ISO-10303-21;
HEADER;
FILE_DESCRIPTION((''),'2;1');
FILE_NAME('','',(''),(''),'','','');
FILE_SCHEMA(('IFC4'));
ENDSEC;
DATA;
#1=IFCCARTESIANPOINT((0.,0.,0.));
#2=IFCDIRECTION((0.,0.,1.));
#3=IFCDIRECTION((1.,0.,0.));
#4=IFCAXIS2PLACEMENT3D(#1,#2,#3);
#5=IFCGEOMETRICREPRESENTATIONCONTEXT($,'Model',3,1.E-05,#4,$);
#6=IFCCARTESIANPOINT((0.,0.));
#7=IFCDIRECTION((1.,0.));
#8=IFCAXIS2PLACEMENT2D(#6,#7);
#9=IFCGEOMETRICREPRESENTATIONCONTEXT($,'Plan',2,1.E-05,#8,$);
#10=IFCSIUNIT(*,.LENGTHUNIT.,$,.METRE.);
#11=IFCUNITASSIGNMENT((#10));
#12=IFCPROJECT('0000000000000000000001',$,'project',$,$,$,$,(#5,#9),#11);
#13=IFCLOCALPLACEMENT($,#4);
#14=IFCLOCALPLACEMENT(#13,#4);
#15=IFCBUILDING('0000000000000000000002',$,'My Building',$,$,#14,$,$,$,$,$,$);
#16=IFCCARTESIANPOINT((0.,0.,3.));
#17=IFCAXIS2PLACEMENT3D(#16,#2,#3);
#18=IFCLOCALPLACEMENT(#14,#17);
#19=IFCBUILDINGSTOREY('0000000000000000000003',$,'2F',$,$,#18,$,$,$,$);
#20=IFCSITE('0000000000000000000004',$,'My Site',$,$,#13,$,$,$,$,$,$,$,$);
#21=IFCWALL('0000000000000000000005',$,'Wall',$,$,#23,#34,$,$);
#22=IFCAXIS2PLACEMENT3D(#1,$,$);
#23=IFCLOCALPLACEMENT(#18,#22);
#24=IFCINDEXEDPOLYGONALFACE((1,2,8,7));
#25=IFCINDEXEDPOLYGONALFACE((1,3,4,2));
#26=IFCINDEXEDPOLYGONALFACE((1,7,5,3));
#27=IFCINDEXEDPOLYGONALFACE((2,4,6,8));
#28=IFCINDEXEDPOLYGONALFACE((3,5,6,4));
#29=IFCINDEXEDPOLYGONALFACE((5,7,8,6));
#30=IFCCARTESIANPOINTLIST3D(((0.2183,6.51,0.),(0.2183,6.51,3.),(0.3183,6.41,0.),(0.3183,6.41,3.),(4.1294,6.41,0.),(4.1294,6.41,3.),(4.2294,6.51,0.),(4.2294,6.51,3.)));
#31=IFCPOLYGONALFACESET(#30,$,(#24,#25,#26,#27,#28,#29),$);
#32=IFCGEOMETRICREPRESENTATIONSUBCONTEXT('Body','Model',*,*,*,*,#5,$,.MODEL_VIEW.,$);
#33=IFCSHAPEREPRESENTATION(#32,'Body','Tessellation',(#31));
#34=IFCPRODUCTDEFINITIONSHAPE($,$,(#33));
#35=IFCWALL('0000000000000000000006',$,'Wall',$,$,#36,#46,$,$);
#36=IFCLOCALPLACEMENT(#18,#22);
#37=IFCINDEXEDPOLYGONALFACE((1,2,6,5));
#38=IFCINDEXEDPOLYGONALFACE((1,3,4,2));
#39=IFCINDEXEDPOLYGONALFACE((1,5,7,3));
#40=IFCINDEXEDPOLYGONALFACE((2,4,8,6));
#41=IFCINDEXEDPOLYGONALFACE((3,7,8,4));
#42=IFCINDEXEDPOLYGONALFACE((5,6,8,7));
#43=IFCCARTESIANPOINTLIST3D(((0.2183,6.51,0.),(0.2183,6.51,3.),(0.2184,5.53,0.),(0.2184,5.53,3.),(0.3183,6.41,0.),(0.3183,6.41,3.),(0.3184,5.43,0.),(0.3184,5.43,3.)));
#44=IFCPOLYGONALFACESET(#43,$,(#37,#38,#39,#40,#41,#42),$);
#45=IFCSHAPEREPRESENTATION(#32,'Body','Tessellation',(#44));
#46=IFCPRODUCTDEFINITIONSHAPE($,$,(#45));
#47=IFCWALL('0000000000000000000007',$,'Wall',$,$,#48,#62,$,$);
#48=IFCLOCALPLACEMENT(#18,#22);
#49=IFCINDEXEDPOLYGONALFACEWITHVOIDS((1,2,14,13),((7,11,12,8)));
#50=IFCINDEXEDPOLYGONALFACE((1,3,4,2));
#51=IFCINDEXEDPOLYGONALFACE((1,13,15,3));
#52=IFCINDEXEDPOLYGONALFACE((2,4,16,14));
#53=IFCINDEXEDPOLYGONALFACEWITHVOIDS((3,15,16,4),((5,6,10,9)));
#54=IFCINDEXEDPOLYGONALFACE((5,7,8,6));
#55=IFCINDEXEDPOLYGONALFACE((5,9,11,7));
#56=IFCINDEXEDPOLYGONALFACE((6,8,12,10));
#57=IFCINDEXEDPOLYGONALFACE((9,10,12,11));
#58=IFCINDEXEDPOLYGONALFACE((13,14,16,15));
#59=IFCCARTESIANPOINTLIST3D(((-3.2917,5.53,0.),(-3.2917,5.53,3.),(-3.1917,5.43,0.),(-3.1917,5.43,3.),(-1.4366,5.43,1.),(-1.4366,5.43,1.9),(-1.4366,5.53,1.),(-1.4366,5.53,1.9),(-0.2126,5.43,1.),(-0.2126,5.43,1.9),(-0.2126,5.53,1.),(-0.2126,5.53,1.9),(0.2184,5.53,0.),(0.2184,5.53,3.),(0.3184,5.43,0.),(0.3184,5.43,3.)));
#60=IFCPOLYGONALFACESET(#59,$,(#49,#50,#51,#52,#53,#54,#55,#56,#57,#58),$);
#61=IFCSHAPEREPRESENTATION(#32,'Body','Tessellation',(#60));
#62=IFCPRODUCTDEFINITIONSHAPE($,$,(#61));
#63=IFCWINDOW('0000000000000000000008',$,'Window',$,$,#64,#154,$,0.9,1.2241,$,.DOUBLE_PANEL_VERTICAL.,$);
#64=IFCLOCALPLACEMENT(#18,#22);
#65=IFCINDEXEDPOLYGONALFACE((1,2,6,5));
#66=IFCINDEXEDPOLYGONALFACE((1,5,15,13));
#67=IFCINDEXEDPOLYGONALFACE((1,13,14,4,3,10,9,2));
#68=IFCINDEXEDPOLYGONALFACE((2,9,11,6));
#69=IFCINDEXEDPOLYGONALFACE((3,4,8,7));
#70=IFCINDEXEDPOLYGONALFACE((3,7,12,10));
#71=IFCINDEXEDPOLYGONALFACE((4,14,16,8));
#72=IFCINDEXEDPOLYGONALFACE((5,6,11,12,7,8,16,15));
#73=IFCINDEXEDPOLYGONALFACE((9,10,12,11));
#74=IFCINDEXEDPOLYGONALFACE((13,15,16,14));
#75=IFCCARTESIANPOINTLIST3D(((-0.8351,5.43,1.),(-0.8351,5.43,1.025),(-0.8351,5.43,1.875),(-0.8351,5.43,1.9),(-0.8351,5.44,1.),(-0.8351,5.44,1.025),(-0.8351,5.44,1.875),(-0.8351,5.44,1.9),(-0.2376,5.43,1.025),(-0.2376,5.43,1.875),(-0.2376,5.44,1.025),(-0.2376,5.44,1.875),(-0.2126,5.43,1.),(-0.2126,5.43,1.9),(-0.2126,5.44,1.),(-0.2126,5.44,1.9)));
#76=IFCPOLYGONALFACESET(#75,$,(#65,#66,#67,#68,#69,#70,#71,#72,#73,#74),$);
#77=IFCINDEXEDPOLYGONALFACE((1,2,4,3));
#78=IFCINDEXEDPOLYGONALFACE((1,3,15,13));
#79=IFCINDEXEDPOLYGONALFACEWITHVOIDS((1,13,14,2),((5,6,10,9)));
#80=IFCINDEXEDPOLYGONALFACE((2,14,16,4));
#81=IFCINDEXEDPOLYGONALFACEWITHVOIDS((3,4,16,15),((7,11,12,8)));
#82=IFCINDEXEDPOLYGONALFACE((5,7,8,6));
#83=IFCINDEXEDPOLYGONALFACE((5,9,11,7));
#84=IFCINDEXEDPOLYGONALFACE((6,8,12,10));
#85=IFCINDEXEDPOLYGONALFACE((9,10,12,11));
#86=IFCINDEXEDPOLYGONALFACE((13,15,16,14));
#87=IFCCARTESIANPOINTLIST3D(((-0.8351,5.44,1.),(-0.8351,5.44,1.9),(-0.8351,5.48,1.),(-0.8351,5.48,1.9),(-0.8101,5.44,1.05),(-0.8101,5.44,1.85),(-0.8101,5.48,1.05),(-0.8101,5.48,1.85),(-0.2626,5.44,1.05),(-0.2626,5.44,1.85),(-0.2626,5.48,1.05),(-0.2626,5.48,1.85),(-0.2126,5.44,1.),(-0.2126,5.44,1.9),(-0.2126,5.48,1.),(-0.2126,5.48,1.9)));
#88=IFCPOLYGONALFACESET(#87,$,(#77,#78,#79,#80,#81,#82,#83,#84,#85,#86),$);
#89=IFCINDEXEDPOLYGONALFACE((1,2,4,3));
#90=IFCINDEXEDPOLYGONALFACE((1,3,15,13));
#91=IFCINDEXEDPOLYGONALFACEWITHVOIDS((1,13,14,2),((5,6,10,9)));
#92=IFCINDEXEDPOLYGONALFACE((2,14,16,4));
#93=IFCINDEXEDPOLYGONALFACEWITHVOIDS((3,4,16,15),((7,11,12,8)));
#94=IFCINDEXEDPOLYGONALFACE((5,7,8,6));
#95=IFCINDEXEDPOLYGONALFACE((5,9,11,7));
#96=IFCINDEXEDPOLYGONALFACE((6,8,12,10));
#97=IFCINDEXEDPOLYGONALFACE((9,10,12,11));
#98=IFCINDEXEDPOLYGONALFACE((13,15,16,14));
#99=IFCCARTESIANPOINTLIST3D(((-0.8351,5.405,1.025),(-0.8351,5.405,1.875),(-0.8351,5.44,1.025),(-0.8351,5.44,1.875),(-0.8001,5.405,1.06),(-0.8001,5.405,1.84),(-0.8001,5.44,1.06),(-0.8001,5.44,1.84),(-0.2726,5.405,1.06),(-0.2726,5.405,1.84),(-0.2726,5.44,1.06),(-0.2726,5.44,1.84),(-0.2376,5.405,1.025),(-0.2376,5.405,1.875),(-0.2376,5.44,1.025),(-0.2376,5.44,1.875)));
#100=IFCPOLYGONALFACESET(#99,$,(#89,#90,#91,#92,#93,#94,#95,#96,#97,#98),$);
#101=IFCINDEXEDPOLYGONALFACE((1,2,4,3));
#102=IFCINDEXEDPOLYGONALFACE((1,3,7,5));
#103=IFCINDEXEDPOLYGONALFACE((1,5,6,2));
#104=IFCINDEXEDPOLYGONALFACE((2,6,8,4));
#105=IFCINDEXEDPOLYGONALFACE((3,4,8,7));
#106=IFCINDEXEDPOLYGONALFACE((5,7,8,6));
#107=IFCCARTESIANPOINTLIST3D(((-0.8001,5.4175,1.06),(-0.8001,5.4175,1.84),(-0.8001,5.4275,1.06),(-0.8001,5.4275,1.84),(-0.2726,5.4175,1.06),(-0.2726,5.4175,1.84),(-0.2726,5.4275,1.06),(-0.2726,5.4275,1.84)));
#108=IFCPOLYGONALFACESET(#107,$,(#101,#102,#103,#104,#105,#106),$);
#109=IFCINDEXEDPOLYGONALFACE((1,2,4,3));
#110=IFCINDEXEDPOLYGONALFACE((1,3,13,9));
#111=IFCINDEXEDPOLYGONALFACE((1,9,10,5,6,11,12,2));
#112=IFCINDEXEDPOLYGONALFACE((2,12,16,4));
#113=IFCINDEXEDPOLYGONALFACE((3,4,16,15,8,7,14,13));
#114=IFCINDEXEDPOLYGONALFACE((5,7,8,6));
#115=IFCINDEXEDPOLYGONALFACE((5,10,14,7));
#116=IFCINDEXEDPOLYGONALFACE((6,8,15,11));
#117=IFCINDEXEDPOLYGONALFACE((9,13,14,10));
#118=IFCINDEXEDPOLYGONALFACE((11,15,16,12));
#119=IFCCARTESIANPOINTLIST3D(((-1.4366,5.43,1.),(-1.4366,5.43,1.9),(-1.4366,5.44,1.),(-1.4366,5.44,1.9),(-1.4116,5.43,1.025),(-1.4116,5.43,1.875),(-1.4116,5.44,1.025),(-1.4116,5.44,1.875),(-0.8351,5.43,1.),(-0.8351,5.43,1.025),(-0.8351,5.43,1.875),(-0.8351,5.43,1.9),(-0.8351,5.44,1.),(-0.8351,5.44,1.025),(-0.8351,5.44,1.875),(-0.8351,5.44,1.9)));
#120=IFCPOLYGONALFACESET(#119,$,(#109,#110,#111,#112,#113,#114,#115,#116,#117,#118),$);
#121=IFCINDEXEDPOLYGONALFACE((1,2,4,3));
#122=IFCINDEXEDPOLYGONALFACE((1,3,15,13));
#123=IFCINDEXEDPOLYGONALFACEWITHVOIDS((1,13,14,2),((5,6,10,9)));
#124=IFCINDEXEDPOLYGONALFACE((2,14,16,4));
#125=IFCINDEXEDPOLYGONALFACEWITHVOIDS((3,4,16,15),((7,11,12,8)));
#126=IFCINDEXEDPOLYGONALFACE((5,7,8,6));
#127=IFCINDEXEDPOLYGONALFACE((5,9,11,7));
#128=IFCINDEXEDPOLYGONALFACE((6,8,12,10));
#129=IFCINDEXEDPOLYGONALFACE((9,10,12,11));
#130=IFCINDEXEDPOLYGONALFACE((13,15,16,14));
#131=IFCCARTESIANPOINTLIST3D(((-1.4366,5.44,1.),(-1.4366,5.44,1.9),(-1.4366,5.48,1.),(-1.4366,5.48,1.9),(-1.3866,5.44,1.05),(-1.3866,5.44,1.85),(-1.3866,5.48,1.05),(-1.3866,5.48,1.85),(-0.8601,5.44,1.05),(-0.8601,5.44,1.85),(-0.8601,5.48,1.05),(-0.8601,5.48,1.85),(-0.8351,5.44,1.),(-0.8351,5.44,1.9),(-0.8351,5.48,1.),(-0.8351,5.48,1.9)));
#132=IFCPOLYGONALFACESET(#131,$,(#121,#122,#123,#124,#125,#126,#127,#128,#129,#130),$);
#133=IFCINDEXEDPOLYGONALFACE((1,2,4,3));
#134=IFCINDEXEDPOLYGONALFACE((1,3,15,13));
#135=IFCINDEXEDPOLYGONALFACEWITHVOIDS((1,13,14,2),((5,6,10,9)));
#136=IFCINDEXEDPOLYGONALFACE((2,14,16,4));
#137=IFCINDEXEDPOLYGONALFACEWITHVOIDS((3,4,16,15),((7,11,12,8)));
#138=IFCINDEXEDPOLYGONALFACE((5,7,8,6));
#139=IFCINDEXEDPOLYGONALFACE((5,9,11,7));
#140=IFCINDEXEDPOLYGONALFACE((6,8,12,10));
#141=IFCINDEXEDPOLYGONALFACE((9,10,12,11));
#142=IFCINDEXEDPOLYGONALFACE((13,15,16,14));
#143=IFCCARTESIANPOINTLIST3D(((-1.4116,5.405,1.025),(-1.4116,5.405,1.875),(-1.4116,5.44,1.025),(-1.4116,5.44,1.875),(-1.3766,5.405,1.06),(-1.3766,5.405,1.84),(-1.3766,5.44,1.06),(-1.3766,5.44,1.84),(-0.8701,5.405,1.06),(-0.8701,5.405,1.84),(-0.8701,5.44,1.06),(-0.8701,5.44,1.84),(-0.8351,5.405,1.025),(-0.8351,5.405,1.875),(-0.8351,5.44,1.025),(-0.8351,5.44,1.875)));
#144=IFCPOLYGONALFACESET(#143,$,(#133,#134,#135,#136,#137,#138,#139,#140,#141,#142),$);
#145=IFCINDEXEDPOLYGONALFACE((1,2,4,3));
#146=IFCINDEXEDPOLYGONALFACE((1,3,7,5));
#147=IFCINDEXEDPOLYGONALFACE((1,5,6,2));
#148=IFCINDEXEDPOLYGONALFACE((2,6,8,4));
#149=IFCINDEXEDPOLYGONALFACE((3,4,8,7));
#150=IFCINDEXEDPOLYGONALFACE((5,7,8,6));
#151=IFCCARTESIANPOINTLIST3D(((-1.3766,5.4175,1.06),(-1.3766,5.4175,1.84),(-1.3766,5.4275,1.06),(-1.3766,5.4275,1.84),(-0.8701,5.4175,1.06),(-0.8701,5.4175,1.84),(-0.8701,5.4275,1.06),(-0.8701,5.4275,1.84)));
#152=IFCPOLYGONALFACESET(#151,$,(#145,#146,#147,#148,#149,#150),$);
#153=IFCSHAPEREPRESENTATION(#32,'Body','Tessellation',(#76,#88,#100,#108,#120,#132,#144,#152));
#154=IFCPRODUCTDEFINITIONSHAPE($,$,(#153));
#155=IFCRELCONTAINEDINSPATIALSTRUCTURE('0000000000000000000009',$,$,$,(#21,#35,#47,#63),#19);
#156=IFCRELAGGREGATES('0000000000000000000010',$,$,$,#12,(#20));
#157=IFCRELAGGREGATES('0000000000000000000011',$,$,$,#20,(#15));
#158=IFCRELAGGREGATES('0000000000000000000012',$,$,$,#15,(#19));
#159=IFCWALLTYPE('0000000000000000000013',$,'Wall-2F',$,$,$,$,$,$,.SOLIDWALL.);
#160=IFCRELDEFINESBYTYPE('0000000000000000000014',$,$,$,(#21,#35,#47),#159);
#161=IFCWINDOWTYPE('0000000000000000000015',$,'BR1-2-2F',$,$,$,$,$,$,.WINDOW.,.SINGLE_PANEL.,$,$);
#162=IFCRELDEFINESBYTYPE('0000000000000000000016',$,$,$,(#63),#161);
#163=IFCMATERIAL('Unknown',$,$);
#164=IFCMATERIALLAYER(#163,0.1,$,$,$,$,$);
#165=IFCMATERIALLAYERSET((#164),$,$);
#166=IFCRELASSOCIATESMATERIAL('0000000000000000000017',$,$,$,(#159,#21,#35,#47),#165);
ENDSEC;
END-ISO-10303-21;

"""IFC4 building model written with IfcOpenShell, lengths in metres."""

from ifc_helpers import new_model, entity, si_unit, frame, origin_with_axes, origin_2d_with_axis, place, context, subcontext, project, spatial, line, indexed_curve, outline, extrude, shape, source, transform, mapped, material, layer, layer_set, layer_usage, type_object, type_shapes, element, fill, save


model = new_model("IFC4")

# Units and contexts
model_context = context("Model", 3, precision=1e-05, world=origin_with_axes())
plan_context = context("Plan", 2, precision=1e-05, world=origin_2d_with_axis())
body_context_1 = subcontext(model_context, "Body", "Model", "MODEL_VIEW")
body_context_2 = subcontext(plan_context, "Body", "Plan", "PLAN_VIEW")
ifc_project = project(units=[si_unit("LENGTHUNIT", "METRE")], contexts=[model_context, plan_context])

# Site, building, storey
site_placement = place(None, origin_with_axes())
site = spatial("IfcSite", under=ifc_project, at=site_placement, Name="My Site")
building_placement = place(site_placement, origin_with_axes())
building = spatial("IfcBuilding", under=site, at=building_placement, Name="My Building")
storey_placement = place(building_placement, frame((0.0, 0.0, 3.0), z_axis=(0.0, 0.0, 1.0), x_axis=(1.0, 0.0, 0.0)))
storey = spatial("IfcBuildingStorey", under=building, at=storey_placement, Name="2F")

# Walls
ifc_material = material(Name="Unknown")
ifc_layer = layer(ifc_material, 0.1)
ifc_layer_set = layer_set([ifc_layer])
ifc_layer_usage_1 = layer_usage(ifc_layer_set, "AXIS2", "POSITIVE", 0.0)
wall_type = type_object("IfcWallType", Name="Wall-2F", PredefinedType="SOLIDWALL", material=ifc_layer_set)
wall_1_placement = place(storey_placement, frame((4.2294, 6.51, 0.0), z_axis=(0.0, 0.0, 1.0), x_axis=(-1.0, 0.0, 0.0)))
element("IfcWall", 1, at=wall_1_placement, inside=storey, type_object=wall_type, material=ifc_layer_usage_1, Name="Wall", context=body_context_1, shape_type="SweptSolid", body=[
    extrude(outline(indexed_curve([(0.0, 0.0), (0.1, 0.1), (3.9111, 0.1), (4.0111, 0.0)], segments=[line(1, 2, 3, 4, 1)])), origin_with_axes(), (0.0, 0.0, 1.0), 3.0),
])
ifc_layer_usage_2 = layer_usage(ifc_layer_set, "AXIS2", "POSITIVE", 0.0)
wall_2_placement = place(storey_placement, frame((0.2183, 6.51, 0.0), z_axis=(0.0, 0.0, 1.0), x_axis=(0.0, -1.0, 0.0)))
element("IfcWall", 2, at=wall_2_placement, inside=storey, type_object=wall_type, material=ifc_layer_usage_2, Name="Wall", context=body_context_1, shape_type="SweptSolid", body=[
    extrude(outline(indexed_curve([(0.0, 0.0), (0.1, 0.1), (1.08, 0.1), (0.98, 0.0)], segments=[line(1, 2, 3, 4, 1)])), origin_with_axes(), (0.0, 0.0, 1.0), 3.0),
])

# Wall, opening, window
ifc_layer_usage_3 = layer_usage(ifc_layer_set, "AXIS2", "POSITIVE", 0.0)
wall_3_placement = place(storey_placement, frame((0.2184, 5.53, 0.0), z_axis=(0.0, 0.0, 1.0), x_axis=(-1.0, 0.0, 0.0)))
wall_3 = element("IfcWall", 3, at=wall_3_placement, inside=storey, type_object=wall_type, material=ifc_layer_usage_3, Name="Wall", context=body_context_1, shape_type="SweptSolid", body=[
    extrude(outline(indexed_curve([(0.0, 0.0), (-0.1, 0.1), (3.41, 0.1), (3.51, 0.0)], segments=[line(1, 2, 3, 4, 1)])), origin_with_axes(), (0.0, 0.0, 1.0), 3.0),
])
shared_shape_1 = source(origin_with_axes(), body_context_1, "Body", "SweptSolid", [
    extrude(outline(indexed_curve([(0.0, 0.0), (1.2241, 0.0), (1.2241, 0.9), (0.0, 0.9)], segments=[line(1, 2, 3, 4, 1)])), frame((0.0, -0.6, 0.0), z_axis=(0.0, -1.0, 0.0), x_axis=(1.0, 0.0, 0.0)), (0.0, 0.0, -1.0), 1.2),
])
opening_1_placement = place(wall_3_placement, frame((0.4309, 0.0, 1.0), z_axis=(0.0, 0.0, 1.0), x_axis=(1.0, 0.0, 0.0)))
opening_1 = element("IfcOpeningElement", 4, at=opening_1_placement, cuts=wall_3, PredefinedType="OPENING", context=body_context_1, shape_type="MappedRepresentation", body=[
    mapped(shared_shape_1, transform((0.0, 0.0, 0.0), x_axis=(1.0, 0.0, 0.0), y_axis=(0.0, 1.0, 0.0), z_axis=(0.0, 0.0, 1.0), scale=1.0)),
])
window_type_1 = type_object("IfcWindowType", Name="BR1-2-2F", PartitioningType="SINGLE_PANEL", PredefinedType="WINDOW")
shared_shape_2 = source(origin_with_axes(), body_context_1, "Body", "SweptSolid", [
    extrude(outline(indexed_curve([(0.6225, 0.0), (0.0, 0.0), (0.0, 0.9), (0.6225, 0.9), (0.6225, 0.875), (0.025, 0.875), (0.025, 0.025), (0.6225, 0.025)], segments=[line(1, 2, 3, 4, 5, 6, 7, 8, 1)])), frame((0.0, 0.09, 0.0), z_axis=(0.0, -1.0, 0.0), x_axis=(1.0, 0.0, 0.0)), (0.0, 0.0, -1.0), 0.01),
    extrude(outline(indexed_curve([(0.0, 0.0), (0.6225, 0.0), (0.6225, 0.9), (0.0, 0.9)], segments=[line(1, 2, 3, 4, 1)]), holes=[indexed_curve([(0.05, 0.05), (0.5975, 0.05), (0.5975, 0.85), (0.05, 0.85)], segments=[line(1, 2, 3, 4, 1)])]), frame((0.0, 0.05, 0.0), z_axis=(0.0, -1.0, 0.0), x_axis=(1.0, 0.0, 0.0)), (0.0, 0.0, -1.0), 0.04),
    extrude(outline(indexed_curve([(0.0, 0.0), (0.5975, 0.0), (0.5975, 0.85), (0.0, 0.85)], segments=[line(1, 2, 3, 4, 1)]), holes=[indexed_curve([(0.035, 0.035), (0.5625, 0.035), (0.5625, 0.815), (0.035, 0.815)], segments=[line(1, 2, 3, 4, 1)])]), frame((0.025, 0.09, 0.025), z_axis=(0.0, -1.0, 0.0), x_axis=(1.0, 0.0, 0.0)), (0.0, 0.0, -1.0), 0.035),
    extrude(outline(indexed_curve([(0.035, 0.035), (0.5625, 0.035), (0.5625, 0.815), (0.035, 0.815)], segments=[line(1, 2, 3, 4, 1)])), frame((0.025, 0.1025, 0.025), z_axis=(0.0, -1.0, 0.0), x_axis=(1.0, 0.0, 0.0)), (0.0, 0.0, -1.0), 0.01),
    extrude(outline(indexed_curve([(0.0, 0.9), (0.6016, 0.9), (0.6016, 0.0), (0.0, 0.0), (0.0, 0.025), (0.5766, 0.025), (0.5766, 0.875), (0.0, 0.875)], segments=[line(1, 2, 3, 4, 5, 6, 7, 8, 1)])), frame((0.6225, 0.09, 0.0), z_axis=(0.0, -1.0, 0.0), x_axis=(1.0, 0.0, 0.0)), (0.0, 0.0, -1.0), 0.01),
    extrude(outline(indexed_curve([(0.0, 0.0), (0.6016, 0.0), (0.6016, 0.9), (0.0, 0.9)], segments=[line(1, 2, 3, 4, 1)]), holes=[indexed_curve([(0.025, 0.05), (0.5516, 0.05), (0.5516, 0.85), (0.025, 0.85)], segments=[line(1, 2, 3, 4, 1)])]), frame((0.6225, 0.05, 0.0), z_axis=(0.0, -1.0, 0.0), x_axis=(1.0, 0.0, 0.0)), (0.0, 0.0, -1.0), 0.04),
    extrude(outline(indexed_curve([(0.0, 0.0), (0.5766, 0.0), (0.5766, 0.85), (0.0, 0.85)], segments=[line(1, 2, 3, 4, 1)]), holes=[indexed_curve([(0.035, 0.035), (0.5416, 0.035), (0.5416, 0.815), (0.035, 0.815)], segments=[line(1, 2, 3, 4, 1)])]), frame((0.6225, 0.09, 0.025), z_axis=(0.0, -1.0, 0.0), x_axis=(1.0, 0.0, 0.0)), (0.0, 0.0, -1.0), 0.035),
    extrude(outline(indexed_curve([(0.035, 0.035), (0.5416, 0.035), (0.5416, 0.815), (0.035, 0.815)], segments=[line(1, 2, 3, 4, 1)])), frame((0.6225, 0.1025, 0.025), z_axis=(0.0, -1.0, 0.0), x_axis=(1.0, 0.0, 0.0)), (0.0, 0.0, -1.0), 0.01),
])
shared_shape_3 = source(origin_with_axes(), body_context_2, "Body", "Curve2D", [
    entity("IfcIndexedPolyCurve", entity("IfcCartesianPointList2D", [[0.05, 0.05], [0.5975, 0.05]])),
    entity("IfcIndexedPolyCurve", entity("IfcCartesianPointList2D", [[0.0, 0.1], [0.025, 0.1], [0.025, 0.09], [0.05, 0.09], [0.05, 0.05], [0.0, 0.05]]), [entity("IfcLineIndex", [1, 2, 3, 4, 5, 6, 1])]),
    entity("IfcIndexedPolyCurve", entity("IfcCartesianPointList2D", [[0.6225, 0.1], [0.6225, 0.1], [0.6225, 0.09], [0.5975, 0.09], [0.5975, 0.05], [0.6225, 0.05]])),
    entity("IfcIndexedPolyCurve", entity("IfcCartesianPointList2D", [[0.025, 0.09], [0.06, 0.09], [0.06, 0.125], [0.025, 0.125]]), [entity("IfcLineIndex", [1, 2, 3, 4, 1])]),
    entity("IfcIndexedPolyCurve", entity("IfcCartesianPointList2D", [[0.6225, 0.09], [0.5875, 0.09], [0.5875, 0.125], [0.6225, 0.125]]), [entity("IfcLineIndex", [1, 2, 3, 4, 1])]),
    entity("IfcIndexedPolyCurve", entity("IfcCartesianPointList2D", [[0.06, 0.09], [0.5875, 0.09]])),
    entity("IfcIndexedPolyCurve", entity("IfcCartesianPointList2D", [[0.06, 0.125], [0.5875, 0.125]])),
    entity("IfcIndexedPolyCurve", entity("IfcCartesianPointList2D", [[0.06, 0.1075], [0.5875, 0.1075]])),
    entity("IfcIndexedPolyCurve", entity("IfcCartesianPointList2D", [[0.6475, 0.05], [1.1741, 0.05]])),
    entity("IfcIndexedPolyCurve", entity("IfcCartesianPointList2D", [[0.6225, 0.1], [0.6225, 0.1], [0.6225, 0.09], [0.6475, 0.09], [0.6475, 0.05], [0.6225, 0.05]])),
    entity("IfcIndexedPolyCurve", entity("IfcCartesianPointList2D", [[1.2241, 0.1], [1.1991, 0.1], [1.1991, 0.09], [1.1741, 0.09], [1.1741, 0.05], [1.2241, 0.05]]), [entity("IfcLineIndex", [1, 2, 3, 4, 5, 6, 1])]),
    entity("IfcIndexedPolyCurve", entity("IfcCartesianPointList2D", [[0.6225, 0.09], [0.6575, 0.09], [0.6575, 0.125], [0.6225, 0.125]]), [entity("IfcLineIndex", [1, 2, 3, 4, 1])]),
    entity("IfcIndexedPolyCurve", entity("IfcCartesianPointList2D", [[1.1991, 0.09], [1.1641, 0.09], [1.1641, 0.125], [1.1991, 0.125]]), [entity("IfcLineIndex", [1, 2, 3, 4, 1])]),
    entity("IfcIndexedPolyCurve", entity("IfcCartesianPointList2D", [[0.6575, 0.09], [1.1641, 0.09]])),
    entity("IfcIndexedPolyCurve", entity("IfcCartesianPointList2D", [[0.6575, 0.125], [1.1641, 0.125]])),
    entity("IfcIndexedPolyCurve", entity("IfcCartesianPointList2D", [[0.6575, 0.1075], [1.1641, 0.1075]])),
])
type_shapes(window_type_1, [shared_shape_2, shared_shape_3])
window_1_placement = place(opening_1_placement, frame((0.0, 0.0, 0.0), z_axis=(0.0, 0.0, 1.0), x_axis=(1.0, 0.0, 0.0)))
window_1 = element("IfcWindow", 5, at=window_1_placement, inside=storey, type_object=window_type_1, Name="Window", OverallHeight=0.9, OverallWidth=1.2241, PartitioningType="DOUBLE_PANEL_VERTICAL", shapes=[
    shape(body_context_1, "Body", "MappedRepresentation", [mapped(shared_shape_2, transform((0.0, 0.0, 0.0), x_axis=(1.0, 0.0, 0.0), y_axis=(0.0, 1.0, 0.0), z_axis=(0.0, 0.0, 1.0), scale=1.0))]),
    shape(body_context_2, "Body", "MappedRepresentation", [mapped(shared_shape_3, transform((0.0, 0.0, 0.0), x_axis=(1.0, 0.0, 0.0), y_axis=(0.0, 1.0, 0.0), z_axis=(0.0, 0.0, 1.0), scale=1.0))]),
])
fill(opening_1, window_1)

save(model, "model.ifc")
